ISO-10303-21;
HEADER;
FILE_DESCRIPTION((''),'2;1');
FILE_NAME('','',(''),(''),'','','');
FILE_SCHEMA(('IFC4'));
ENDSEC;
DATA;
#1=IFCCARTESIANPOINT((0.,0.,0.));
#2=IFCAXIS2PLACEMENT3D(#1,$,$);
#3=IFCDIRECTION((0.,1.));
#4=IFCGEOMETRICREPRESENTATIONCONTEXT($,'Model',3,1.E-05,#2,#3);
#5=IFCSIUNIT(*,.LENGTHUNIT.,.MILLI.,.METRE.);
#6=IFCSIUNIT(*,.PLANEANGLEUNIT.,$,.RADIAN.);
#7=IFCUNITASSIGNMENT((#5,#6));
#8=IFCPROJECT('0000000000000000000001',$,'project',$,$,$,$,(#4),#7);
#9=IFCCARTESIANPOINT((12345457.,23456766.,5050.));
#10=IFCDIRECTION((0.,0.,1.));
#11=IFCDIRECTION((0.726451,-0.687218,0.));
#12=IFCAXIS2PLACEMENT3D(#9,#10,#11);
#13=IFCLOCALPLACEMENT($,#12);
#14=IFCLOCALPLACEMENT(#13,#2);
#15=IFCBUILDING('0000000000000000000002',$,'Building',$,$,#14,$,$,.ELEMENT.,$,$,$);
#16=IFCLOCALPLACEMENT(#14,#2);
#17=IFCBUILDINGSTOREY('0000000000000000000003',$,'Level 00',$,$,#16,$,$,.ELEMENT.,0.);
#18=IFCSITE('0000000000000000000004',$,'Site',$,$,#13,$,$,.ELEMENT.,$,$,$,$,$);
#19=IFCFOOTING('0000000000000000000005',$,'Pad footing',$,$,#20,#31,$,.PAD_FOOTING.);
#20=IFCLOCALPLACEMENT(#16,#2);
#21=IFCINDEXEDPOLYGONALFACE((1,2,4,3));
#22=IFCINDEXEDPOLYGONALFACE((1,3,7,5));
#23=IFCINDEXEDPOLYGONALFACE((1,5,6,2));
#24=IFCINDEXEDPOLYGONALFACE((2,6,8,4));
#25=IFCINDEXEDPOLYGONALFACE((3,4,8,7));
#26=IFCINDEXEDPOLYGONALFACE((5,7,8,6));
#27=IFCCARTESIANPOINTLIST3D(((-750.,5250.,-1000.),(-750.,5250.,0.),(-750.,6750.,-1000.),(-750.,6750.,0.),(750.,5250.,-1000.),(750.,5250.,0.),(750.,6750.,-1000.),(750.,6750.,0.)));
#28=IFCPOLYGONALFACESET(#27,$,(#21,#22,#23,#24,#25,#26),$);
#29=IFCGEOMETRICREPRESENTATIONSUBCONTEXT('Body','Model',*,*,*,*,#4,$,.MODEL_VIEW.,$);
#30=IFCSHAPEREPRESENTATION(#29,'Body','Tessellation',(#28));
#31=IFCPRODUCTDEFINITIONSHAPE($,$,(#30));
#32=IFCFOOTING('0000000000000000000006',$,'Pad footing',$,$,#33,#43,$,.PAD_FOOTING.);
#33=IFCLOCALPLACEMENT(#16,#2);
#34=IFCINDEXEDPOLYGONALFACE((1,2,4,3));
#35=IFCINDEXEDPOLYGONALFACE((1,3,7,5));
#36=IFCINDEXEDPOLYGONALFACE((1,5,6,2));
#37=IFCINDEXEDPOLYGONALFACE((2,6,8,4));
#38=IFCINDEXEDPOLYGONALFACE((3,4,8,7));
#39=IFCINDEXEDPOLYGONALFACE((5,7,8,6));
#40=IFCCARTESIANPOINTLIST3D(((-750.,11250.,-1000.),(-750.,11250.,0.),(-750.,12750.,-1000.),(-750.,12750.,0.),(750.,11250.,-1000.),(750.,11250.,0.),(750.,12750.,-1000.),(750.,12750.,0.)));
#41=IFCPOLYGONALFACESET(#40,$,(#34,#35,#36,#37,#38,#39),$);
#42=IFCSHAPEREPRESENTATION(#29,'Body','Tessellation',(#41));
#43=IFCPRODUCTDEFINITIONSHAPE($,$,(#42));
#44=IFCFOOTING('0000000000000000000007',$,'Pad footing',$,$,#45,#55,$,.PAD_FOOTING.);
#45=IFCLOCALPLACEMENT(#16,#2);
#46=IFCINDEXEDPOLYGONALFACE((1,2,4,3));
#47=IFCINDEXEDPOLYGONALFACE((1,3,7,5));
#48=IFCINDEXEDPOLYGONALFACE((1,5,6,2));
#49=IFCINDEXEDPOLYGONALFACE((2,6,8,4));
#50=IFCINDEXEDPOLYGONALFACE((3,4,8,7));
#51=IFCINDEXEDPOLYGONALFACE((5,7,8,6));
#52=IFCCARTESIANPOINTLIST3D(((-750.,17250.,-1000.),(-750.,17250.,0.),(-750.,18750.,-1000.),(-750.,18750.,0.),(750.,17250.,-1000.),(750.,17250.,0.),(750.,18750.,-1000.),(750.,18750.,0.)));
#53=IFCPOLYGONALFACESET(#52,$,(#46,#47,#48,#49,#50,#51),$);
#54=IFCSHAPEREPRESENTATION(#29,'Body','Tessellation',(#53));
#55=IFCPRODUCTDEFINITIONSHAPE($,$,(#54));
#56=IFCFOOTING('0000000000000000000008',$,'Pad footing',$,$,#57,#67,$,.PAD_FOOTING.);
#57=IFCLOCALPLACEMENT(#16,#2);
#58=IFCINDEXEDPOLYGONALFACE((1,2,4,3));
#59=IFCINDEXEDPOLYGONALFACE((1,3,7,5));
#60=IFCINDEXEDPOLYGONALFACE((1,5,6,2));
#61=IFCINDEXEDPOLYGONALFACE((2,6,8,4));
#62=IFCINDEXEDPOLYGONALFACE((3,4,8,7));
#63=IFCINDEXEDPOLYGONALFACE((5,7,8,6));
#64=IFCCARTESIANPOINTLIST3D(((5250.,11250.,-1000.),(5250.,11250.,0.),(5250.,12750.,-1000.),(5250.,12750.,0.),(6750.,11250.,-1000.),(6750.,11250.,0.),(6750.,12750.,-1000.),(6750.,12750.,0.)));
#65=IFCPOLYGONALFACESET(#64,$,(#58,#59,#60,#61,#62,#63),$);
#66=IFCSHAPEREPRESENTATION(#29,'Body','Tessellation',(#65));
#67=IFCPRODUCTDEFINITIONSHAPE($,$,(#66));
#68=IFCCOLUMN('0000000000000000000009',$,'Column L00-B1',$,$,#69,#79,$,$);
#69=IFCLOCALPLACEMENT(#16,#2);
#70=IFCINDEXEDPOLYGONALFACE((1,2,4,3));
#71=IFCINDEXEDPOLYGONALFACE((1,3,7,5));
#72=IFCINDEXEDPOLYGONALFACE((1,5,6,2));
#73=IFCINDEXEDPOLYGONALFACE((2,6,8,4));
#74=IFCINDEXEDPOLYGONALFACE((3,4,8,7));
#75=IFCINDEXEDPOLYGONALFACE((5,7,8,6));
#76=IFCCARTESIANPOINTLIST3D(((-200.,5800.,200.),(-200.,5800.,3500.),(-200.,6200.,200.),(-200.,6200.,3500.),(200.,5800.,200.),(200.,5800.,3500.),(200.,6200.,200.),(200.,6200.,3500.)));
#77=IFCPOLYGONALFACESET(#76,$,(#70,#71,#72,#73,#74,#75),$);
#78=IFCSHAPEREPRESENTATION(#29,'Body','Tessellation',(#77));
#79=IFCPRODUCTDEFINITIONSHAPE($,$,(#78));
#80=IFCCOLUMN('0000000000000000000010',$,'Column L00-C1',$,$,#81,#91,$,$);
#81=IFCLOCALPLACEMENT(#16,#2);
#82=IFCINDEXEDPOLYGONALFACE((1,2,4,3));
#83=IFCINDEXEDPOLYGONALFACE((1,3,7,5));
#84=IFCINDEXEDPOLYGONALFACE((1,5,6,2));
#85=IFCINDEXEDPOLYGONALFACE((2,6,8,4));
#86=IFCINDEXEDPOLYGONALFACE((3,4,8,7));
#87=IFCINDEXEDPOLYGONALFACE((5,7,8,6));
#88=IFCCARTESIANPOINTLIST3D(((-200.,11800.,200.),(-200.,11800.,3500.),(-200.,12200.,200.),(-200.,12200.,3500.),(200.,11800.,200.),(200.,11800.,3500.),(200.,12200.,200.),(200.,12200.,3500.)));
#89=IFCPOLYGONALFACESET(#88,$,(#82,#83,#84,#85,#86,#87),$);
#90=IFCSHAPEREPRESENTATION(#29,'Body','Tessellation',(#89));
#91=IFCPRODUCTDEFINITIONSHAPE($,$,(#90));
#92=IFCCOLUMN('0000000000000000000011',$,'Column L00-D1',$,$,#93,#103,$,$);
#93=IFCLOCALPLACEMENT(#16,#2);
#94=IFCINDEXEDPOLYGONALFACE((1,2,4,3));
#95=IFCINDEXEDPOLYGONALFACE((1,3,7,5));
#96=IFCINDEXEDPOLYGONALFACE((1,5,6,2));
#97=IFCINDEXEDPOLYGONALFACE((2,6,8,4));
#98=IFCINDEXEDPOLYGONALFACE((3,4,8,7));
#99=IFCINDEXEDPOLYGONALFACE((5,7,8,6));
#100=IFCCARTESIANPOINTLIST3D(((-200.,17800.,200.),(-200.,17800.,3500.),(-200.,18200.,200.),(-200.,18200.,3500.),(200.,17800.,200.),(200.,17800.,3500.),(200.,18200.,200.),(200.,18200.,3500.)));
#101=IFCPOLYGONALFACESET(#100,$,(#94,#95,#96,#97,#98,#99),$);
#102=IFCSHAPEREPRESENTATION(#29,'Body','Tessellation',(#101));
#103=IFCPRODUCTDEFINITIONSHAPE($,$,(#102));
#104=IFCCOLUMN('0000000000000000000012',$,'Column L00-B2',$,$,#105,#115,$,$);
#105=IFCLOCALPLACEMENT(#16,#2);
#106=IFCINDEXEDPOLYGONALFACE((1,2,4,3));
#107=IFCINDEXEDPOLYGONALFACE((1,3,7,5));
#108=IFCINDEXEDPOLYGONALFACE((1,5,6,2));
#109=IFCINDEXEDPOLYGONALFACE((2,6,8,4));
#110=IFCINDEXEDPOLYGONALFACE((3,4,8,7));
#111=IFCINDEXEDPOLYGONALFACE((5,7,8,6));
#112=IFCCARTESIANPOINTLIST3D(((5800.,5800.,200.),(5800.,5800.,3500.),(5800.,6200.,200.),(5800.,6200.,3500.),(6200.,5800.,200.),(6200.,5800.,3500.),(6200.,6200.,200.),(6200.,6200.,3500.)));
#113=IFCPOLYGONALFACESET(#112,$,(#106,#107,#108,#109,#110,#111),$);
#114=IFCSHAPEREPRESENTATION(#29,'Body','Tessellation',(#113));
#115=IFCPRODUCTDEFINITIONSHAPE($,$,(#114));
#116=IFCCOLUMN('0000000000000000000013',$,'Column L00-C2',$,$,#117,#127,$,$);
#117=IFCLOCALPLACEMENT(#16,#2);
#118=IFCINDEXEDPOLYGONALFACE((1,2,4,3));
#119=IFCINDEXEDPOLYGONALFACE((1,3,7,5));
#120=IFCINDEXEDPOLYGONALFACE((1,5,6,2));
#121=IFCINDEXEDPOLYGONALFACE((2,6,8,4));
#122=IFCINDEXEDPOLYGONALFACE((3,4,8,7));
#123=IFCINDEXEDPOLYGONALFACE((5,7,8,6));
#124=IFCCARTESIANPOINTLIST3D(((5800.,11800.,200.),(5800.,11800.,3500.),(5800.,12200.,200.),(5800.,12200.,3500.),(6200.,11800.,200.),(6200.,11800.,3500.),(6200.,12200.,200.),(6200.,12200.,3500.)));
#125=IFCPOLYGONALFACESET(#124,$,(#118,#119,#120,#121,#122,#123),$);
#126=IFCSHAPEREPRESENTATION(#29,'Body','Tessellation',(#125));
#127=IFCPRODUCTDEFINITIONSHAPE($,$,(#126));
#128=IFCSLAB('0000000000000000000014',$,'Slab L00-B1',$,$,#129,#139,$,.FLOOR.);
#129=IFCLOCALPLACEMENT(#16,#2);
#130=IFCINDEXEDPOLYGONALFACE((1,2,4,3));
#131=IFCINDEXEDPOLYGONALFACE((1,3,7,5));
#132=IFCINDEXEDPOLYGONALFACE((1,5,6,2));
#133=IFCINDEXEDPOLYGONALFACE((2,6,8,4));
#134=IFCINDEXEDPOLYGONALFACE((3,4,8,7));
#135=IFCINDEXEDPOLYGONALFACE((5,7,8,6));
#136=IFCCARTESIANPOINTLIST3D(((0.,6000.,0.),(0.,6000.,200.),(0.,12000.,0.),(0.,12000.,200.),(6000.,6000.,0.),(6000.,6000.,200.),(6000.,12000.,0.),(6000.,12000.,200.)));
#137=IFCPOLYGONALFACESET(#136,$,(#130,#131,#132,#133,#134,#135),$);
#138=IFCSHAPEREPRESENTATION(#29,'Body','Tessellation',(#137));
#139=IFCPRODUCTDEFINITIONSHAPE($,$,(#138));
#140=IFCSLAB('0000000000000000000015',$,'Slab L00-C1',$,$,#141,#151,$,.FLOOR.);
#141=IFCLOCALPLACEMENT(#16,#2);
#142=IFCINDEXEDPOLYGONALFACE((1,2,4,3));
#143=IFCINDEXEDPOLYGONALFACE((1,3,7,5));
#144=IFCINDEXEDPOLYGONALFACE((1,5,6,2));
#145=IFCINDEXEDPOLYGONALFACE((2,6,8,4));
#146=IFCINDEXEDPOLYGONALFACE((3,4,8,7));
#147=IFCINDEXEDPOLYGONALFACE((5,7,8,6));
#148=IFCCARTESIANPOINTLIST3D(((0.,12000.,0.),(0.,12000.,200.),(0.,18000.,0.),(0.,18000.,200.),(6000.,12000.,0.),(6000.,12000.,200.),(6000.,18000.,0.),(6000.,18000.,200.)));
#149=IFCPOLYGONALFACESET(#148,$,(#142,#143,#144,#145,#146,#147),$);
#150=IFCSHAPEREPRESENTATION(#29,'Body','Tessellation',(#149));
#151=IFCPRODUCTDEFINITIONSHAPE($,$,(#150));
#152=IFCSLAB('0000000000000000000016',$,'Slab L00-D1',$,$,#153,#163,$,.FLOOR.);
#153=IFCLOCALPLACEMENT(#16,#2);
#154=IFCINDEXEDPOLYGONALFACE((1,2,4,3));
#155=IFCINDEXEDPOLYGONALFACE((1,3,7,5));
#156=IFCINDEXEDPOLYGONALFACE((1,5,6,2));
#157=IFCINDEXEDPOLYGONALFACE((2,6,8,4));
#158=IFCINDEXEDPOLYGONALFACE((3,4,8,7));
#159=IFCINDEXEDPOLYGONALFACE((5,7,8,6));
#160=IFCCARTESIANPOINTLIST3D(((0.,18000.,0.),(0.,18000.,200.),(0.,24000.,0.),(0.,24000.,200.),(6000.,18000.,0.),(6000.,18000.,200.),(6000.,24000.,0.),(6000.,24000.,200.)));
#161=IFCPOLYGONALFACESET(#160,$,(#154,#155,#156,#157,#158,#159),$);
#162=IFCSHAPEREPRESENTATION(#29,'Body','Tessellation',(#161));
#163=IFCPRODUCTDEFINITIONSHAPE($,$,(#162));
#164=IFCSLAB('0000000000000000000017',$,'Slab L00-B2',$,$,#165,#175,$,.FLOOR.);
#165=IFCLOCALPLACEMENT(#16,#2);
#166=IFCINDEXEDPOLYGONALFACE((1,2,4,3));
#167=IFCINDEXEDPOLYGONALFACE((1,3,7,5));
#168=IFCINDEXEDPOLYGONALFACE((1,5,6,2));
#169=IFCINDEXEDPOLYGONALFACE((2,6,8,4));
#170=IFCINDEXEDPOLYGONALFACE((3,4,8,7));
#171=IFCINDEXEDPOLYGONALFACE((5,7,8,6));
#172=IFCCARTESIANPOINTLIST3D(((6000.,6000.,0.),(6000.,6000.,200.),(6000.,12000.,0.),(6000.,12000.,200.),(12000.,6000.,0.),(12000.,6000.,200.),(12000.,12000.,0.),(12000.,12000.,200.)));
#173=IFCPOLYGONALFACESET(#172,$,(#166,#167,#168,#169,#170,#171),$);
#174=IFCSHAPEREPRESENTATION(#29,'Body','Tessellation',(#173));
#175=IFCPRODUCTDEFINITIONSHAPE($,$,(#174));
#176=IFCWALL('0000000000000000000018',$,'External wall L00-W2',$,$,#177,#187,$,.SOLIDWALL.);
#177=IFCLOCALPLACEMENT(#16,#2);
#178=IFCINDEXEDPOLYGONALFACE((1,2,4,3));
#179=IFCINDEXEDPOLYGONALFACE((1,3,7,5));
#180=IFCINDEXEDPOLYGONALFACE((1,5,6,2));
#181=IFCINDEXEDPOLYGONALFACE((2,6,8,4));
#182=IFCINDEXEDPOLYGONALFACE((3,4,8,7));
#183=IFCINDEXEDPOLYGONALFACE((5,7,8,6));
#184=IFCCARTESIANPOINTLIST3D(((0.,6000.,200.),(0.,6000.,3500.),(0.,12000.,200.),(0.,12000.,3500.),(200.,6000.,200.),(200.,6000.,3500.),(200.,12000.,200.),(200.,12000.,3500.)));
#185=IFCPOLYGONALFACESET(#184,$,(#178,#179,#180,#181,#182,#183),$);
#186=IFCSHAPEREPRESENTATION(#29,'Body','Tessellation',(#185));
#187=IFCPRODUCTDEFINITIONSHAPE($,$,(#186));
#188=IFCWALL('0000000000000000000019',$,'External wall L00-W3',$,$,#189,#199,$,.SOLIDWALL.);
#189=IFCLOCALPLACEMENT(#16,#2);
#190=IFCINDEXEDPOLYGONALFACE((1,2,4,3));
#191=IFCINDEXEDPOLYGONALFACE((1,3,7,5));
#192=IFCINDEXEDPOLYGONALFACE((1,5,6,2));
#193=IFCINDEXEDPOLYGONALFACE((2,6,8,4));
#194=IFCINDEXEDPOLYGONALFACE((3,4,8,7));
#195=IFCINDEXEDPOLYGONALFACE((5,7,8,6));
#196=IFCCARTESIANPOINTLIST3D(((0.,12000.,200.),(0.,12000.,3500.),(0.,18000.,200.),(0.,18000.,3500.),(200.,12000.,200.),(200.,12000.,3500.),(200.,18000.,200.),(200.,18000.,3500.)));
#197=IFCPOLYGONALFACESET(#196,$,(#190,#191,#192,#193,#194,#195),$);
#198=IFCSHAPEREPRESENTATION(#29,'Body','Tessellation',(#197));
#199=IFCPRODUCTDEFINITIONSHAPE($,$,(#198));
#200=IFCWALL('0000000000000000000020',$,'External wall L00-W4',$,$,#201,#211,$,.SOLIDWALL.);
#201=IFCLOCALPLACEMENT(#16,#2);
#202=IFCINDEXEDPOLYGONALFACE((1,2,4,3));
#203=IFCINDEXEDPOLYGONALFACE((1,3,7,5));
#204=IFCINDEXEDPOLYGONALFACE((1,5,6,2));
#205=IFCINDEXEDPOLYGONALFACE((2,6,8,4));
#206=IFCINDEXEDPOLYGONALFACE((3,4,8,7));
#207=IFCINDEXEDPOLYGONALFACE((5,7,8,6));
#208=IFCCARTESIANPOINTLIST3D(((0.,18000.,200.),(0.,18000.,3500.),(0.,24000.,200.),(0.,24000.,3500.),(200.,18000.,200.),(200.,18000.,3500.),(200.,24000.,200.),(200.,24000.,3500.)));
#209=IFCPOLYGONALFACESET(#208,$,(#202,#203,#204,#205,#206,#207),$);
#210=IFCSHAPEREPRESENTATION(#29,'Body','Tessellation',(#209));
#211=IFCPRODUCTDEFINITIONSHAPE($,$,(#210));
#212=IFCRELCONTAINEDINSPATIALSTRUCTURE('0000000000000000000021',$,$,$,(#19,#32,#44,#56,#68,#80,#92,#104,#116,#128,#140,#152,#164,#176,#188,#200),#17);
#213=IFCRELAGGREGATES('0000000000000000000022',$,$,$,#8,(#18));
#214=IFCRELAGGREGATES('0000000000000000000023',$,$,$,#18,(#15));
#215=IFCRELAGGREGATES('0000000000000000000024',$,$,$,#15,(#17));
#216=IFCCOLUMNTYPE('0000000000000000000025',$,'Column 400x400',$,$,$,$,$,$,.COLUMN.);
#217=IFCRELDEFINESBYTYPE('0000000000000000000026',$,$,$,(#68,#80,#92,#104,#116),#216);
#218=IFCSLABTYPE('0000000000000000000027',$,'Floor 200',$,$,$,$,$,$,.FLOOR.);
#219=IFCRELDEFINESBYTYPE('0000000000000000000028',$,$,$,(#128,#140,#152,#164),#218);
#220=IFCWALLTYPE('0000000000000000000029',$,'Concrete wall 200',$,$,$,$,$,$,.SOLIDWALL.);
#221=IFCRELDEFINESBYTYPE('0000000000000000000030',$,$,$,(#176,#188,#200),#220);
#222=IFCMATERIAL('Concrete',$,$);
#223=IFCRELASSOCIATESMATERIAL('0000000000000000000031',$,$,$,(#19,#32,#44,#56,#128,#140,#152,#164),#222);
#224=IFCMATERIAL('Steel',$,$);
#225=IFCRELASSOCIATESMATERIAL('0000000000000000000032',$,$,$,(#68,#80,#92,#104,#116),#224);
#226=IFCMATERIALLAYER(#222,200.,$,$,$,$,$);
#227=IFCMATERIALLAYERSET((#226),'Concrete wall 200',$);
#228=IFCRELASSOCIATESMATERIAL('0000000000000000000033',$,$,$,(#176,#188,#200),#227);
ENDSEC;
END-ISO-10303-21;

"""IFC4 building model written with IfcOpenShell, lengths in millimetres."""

from ifc_helpers import new_model, si_unit, direction, frame, origin, place, context, subcontext, project, spatial, rectangle, extrude, material, layer, layer_set, layer_usage, type_object, element, save


model = new_model("IFC4")

# Units and contexts
model_context = context("Model", 3, precision=1e-05, world=origin(), true_north=direction((0.0, 1.0)))
body_context = subcontext(model_context, "Body", "Model", "MODEL_VIEW")
ifc_project = project(units=[si_unit("LENGTHUNIT", "METRE", prefix="MILLI"), si_unit("PLANEANGLEUNIT", "RADIAN")], contexts=[model_context])

# Site, building, storey
site_placement = place(None, frame((12345457.0, 23456766.0, 5050.0), z_axis=(0.0, 0.0, 1.0), x_axis=(0.726451, -0.687218, 0.0)))
site = spatial("IfcSite", under=ifc_project, at=site_placement, Name="Site", CompositionType="ELEMENT")
building_placement = place(site_placement, origin())
building = spatial("IfcBuilding", under=site, at=building_placement, Name="Building", CompositionType="ELEMENT")
storey_placement = place(building_placement, origin())
storey = spatial("IfcBuildingStorey", under=building, at=storey_placement, Name="Level 00", CompositionType="ELEMENT", Elevation=0.0)

# Footings
ifc_material_1 = material(Name="Concrete")
for number, where, name in (
    (1, (-750.0, 5250.0, -1000.0), "Pad footing"),
    (2, (-750.0, 11250.0, -1000.0), "Pad footing"),
    (3, (-750.0, 17250.0, -1000.0), "Pad footing"),
    (4, (5250.0, 11250.0, -1000.0), "Pad footing"),
):
    element("IfcFooting", number, at=place(storey_placement, frame(where)), inside=storey, material=ifc_material_1, Name=name, PredefinedType="PAD_FOOTING", context=body_context, shape_type="SweptSolid", body=[
        extrude(rectangle(XDim=1500.0, YDim=1500.0), frame((750.0, 750.0, 0.0)), (0.0, 0.0, 1.0), 1000.0),
    ])

# Columns
ifc_material_2 = material(Name="Steel")
column_type = type_object("IfcColumnType", Name="Column 400x400", PredefinedType="COLUMN")
for number, where, name in (
    (5, (-200.0, 5800.0, 200.0), "Column L00-B1"),
    (6, (-200.0, 11800.0, 200.0), "Column L00-C1"),
    (7, (-200.0, 17800.0, 200.0), "Column L00-D1"),
    (8, (5800.0, 5800.0, 200.0), "Column L00-B2"),
    (9, (5800.0, 11800.0, 200.0), "Column L00-C2"),
):
    element("IfcColumn", number, at=place(storey_placement, frame(where)), inside=storey, type_object=column_type, material=ifc_material_2, Name=name, context=body_context, shape_type="SweptSolid", body=[
        extrude(rectangle(XDim=400.0, YDim=400.0), frame((200.0, 200.0, 0.0)), (0.0, 0.0, 1.0), 3300.0),
    ])

# Slabs
slab_type = type_object("IfcSlabType", Name="Floor 200", PredefinedType="FLOOR")
for number, where, name in (
    (10, (0.0, 6000.0, 0.0), "Slab L00-B1"),
    (11, (0.0, 12000.0, 0.0), "Slab L00-C1"),
    (12, (0.0, 18000.0, 0.0), "Slab L00-D1"),
    (13, (6000.0, 6000.0, 0.0), "Slab L00-B2"),
):
    element("IfcSlab", number, at=place(storey_placement, frame(where)), inside=storey, type_object=slab_type, material=ifc_material_1, Name=name, PredefinedType="FLOOR", context=body_context, shape_type="SweptSolid", body=[
        extrude(rectangle(XDim=6000.0, YDim=6000.0), frame((3000.0, 3000.0, 0.0)), (0.0, 0.0, 1.0), 200.0),
    ])

# Walls
ifc_layer_1 = layer(ifc_material_1, 200.0)
ifc_layer_set_1 = layer_set([ifc_layer_1], Name="Concrete wall 200")
ifc_layer_usage_1 = layer_usage(ifc_layer_set_1, "AXIS2", "POSITIVE", 0.0)
wall_type_1 = type_object("IfcWallType", Name="Concrete wall 200", PredefinedType="SOLIDWALL")
for number, where, name in (
    (14, (0.0, 6000.0, 200.0), "External wall L00-W2"),
    (15, (0.0, 12000.0, 200.0), "External wall L00-W3"),
    (16, (0.0, 18000.0, 200.0), "External wall L00-W4"),
):
    element("IfcWall", number, at=place(storey_placement, frame(where)), inside=storey, type_object=wall_type_1, material=ifc_layer_usage_1, Name=name, PredefinedType="SOLIDWALL", context=body_context, shape_type="SweptSolid", body=[
        extrude(rectangle(XDim=200.0, YDim=6000.0), frame((100.0, 3000.0, 0.0)), (0.0, 0.0, 1.0), 3300.0),
    ])

save(model, "model.ifc")
